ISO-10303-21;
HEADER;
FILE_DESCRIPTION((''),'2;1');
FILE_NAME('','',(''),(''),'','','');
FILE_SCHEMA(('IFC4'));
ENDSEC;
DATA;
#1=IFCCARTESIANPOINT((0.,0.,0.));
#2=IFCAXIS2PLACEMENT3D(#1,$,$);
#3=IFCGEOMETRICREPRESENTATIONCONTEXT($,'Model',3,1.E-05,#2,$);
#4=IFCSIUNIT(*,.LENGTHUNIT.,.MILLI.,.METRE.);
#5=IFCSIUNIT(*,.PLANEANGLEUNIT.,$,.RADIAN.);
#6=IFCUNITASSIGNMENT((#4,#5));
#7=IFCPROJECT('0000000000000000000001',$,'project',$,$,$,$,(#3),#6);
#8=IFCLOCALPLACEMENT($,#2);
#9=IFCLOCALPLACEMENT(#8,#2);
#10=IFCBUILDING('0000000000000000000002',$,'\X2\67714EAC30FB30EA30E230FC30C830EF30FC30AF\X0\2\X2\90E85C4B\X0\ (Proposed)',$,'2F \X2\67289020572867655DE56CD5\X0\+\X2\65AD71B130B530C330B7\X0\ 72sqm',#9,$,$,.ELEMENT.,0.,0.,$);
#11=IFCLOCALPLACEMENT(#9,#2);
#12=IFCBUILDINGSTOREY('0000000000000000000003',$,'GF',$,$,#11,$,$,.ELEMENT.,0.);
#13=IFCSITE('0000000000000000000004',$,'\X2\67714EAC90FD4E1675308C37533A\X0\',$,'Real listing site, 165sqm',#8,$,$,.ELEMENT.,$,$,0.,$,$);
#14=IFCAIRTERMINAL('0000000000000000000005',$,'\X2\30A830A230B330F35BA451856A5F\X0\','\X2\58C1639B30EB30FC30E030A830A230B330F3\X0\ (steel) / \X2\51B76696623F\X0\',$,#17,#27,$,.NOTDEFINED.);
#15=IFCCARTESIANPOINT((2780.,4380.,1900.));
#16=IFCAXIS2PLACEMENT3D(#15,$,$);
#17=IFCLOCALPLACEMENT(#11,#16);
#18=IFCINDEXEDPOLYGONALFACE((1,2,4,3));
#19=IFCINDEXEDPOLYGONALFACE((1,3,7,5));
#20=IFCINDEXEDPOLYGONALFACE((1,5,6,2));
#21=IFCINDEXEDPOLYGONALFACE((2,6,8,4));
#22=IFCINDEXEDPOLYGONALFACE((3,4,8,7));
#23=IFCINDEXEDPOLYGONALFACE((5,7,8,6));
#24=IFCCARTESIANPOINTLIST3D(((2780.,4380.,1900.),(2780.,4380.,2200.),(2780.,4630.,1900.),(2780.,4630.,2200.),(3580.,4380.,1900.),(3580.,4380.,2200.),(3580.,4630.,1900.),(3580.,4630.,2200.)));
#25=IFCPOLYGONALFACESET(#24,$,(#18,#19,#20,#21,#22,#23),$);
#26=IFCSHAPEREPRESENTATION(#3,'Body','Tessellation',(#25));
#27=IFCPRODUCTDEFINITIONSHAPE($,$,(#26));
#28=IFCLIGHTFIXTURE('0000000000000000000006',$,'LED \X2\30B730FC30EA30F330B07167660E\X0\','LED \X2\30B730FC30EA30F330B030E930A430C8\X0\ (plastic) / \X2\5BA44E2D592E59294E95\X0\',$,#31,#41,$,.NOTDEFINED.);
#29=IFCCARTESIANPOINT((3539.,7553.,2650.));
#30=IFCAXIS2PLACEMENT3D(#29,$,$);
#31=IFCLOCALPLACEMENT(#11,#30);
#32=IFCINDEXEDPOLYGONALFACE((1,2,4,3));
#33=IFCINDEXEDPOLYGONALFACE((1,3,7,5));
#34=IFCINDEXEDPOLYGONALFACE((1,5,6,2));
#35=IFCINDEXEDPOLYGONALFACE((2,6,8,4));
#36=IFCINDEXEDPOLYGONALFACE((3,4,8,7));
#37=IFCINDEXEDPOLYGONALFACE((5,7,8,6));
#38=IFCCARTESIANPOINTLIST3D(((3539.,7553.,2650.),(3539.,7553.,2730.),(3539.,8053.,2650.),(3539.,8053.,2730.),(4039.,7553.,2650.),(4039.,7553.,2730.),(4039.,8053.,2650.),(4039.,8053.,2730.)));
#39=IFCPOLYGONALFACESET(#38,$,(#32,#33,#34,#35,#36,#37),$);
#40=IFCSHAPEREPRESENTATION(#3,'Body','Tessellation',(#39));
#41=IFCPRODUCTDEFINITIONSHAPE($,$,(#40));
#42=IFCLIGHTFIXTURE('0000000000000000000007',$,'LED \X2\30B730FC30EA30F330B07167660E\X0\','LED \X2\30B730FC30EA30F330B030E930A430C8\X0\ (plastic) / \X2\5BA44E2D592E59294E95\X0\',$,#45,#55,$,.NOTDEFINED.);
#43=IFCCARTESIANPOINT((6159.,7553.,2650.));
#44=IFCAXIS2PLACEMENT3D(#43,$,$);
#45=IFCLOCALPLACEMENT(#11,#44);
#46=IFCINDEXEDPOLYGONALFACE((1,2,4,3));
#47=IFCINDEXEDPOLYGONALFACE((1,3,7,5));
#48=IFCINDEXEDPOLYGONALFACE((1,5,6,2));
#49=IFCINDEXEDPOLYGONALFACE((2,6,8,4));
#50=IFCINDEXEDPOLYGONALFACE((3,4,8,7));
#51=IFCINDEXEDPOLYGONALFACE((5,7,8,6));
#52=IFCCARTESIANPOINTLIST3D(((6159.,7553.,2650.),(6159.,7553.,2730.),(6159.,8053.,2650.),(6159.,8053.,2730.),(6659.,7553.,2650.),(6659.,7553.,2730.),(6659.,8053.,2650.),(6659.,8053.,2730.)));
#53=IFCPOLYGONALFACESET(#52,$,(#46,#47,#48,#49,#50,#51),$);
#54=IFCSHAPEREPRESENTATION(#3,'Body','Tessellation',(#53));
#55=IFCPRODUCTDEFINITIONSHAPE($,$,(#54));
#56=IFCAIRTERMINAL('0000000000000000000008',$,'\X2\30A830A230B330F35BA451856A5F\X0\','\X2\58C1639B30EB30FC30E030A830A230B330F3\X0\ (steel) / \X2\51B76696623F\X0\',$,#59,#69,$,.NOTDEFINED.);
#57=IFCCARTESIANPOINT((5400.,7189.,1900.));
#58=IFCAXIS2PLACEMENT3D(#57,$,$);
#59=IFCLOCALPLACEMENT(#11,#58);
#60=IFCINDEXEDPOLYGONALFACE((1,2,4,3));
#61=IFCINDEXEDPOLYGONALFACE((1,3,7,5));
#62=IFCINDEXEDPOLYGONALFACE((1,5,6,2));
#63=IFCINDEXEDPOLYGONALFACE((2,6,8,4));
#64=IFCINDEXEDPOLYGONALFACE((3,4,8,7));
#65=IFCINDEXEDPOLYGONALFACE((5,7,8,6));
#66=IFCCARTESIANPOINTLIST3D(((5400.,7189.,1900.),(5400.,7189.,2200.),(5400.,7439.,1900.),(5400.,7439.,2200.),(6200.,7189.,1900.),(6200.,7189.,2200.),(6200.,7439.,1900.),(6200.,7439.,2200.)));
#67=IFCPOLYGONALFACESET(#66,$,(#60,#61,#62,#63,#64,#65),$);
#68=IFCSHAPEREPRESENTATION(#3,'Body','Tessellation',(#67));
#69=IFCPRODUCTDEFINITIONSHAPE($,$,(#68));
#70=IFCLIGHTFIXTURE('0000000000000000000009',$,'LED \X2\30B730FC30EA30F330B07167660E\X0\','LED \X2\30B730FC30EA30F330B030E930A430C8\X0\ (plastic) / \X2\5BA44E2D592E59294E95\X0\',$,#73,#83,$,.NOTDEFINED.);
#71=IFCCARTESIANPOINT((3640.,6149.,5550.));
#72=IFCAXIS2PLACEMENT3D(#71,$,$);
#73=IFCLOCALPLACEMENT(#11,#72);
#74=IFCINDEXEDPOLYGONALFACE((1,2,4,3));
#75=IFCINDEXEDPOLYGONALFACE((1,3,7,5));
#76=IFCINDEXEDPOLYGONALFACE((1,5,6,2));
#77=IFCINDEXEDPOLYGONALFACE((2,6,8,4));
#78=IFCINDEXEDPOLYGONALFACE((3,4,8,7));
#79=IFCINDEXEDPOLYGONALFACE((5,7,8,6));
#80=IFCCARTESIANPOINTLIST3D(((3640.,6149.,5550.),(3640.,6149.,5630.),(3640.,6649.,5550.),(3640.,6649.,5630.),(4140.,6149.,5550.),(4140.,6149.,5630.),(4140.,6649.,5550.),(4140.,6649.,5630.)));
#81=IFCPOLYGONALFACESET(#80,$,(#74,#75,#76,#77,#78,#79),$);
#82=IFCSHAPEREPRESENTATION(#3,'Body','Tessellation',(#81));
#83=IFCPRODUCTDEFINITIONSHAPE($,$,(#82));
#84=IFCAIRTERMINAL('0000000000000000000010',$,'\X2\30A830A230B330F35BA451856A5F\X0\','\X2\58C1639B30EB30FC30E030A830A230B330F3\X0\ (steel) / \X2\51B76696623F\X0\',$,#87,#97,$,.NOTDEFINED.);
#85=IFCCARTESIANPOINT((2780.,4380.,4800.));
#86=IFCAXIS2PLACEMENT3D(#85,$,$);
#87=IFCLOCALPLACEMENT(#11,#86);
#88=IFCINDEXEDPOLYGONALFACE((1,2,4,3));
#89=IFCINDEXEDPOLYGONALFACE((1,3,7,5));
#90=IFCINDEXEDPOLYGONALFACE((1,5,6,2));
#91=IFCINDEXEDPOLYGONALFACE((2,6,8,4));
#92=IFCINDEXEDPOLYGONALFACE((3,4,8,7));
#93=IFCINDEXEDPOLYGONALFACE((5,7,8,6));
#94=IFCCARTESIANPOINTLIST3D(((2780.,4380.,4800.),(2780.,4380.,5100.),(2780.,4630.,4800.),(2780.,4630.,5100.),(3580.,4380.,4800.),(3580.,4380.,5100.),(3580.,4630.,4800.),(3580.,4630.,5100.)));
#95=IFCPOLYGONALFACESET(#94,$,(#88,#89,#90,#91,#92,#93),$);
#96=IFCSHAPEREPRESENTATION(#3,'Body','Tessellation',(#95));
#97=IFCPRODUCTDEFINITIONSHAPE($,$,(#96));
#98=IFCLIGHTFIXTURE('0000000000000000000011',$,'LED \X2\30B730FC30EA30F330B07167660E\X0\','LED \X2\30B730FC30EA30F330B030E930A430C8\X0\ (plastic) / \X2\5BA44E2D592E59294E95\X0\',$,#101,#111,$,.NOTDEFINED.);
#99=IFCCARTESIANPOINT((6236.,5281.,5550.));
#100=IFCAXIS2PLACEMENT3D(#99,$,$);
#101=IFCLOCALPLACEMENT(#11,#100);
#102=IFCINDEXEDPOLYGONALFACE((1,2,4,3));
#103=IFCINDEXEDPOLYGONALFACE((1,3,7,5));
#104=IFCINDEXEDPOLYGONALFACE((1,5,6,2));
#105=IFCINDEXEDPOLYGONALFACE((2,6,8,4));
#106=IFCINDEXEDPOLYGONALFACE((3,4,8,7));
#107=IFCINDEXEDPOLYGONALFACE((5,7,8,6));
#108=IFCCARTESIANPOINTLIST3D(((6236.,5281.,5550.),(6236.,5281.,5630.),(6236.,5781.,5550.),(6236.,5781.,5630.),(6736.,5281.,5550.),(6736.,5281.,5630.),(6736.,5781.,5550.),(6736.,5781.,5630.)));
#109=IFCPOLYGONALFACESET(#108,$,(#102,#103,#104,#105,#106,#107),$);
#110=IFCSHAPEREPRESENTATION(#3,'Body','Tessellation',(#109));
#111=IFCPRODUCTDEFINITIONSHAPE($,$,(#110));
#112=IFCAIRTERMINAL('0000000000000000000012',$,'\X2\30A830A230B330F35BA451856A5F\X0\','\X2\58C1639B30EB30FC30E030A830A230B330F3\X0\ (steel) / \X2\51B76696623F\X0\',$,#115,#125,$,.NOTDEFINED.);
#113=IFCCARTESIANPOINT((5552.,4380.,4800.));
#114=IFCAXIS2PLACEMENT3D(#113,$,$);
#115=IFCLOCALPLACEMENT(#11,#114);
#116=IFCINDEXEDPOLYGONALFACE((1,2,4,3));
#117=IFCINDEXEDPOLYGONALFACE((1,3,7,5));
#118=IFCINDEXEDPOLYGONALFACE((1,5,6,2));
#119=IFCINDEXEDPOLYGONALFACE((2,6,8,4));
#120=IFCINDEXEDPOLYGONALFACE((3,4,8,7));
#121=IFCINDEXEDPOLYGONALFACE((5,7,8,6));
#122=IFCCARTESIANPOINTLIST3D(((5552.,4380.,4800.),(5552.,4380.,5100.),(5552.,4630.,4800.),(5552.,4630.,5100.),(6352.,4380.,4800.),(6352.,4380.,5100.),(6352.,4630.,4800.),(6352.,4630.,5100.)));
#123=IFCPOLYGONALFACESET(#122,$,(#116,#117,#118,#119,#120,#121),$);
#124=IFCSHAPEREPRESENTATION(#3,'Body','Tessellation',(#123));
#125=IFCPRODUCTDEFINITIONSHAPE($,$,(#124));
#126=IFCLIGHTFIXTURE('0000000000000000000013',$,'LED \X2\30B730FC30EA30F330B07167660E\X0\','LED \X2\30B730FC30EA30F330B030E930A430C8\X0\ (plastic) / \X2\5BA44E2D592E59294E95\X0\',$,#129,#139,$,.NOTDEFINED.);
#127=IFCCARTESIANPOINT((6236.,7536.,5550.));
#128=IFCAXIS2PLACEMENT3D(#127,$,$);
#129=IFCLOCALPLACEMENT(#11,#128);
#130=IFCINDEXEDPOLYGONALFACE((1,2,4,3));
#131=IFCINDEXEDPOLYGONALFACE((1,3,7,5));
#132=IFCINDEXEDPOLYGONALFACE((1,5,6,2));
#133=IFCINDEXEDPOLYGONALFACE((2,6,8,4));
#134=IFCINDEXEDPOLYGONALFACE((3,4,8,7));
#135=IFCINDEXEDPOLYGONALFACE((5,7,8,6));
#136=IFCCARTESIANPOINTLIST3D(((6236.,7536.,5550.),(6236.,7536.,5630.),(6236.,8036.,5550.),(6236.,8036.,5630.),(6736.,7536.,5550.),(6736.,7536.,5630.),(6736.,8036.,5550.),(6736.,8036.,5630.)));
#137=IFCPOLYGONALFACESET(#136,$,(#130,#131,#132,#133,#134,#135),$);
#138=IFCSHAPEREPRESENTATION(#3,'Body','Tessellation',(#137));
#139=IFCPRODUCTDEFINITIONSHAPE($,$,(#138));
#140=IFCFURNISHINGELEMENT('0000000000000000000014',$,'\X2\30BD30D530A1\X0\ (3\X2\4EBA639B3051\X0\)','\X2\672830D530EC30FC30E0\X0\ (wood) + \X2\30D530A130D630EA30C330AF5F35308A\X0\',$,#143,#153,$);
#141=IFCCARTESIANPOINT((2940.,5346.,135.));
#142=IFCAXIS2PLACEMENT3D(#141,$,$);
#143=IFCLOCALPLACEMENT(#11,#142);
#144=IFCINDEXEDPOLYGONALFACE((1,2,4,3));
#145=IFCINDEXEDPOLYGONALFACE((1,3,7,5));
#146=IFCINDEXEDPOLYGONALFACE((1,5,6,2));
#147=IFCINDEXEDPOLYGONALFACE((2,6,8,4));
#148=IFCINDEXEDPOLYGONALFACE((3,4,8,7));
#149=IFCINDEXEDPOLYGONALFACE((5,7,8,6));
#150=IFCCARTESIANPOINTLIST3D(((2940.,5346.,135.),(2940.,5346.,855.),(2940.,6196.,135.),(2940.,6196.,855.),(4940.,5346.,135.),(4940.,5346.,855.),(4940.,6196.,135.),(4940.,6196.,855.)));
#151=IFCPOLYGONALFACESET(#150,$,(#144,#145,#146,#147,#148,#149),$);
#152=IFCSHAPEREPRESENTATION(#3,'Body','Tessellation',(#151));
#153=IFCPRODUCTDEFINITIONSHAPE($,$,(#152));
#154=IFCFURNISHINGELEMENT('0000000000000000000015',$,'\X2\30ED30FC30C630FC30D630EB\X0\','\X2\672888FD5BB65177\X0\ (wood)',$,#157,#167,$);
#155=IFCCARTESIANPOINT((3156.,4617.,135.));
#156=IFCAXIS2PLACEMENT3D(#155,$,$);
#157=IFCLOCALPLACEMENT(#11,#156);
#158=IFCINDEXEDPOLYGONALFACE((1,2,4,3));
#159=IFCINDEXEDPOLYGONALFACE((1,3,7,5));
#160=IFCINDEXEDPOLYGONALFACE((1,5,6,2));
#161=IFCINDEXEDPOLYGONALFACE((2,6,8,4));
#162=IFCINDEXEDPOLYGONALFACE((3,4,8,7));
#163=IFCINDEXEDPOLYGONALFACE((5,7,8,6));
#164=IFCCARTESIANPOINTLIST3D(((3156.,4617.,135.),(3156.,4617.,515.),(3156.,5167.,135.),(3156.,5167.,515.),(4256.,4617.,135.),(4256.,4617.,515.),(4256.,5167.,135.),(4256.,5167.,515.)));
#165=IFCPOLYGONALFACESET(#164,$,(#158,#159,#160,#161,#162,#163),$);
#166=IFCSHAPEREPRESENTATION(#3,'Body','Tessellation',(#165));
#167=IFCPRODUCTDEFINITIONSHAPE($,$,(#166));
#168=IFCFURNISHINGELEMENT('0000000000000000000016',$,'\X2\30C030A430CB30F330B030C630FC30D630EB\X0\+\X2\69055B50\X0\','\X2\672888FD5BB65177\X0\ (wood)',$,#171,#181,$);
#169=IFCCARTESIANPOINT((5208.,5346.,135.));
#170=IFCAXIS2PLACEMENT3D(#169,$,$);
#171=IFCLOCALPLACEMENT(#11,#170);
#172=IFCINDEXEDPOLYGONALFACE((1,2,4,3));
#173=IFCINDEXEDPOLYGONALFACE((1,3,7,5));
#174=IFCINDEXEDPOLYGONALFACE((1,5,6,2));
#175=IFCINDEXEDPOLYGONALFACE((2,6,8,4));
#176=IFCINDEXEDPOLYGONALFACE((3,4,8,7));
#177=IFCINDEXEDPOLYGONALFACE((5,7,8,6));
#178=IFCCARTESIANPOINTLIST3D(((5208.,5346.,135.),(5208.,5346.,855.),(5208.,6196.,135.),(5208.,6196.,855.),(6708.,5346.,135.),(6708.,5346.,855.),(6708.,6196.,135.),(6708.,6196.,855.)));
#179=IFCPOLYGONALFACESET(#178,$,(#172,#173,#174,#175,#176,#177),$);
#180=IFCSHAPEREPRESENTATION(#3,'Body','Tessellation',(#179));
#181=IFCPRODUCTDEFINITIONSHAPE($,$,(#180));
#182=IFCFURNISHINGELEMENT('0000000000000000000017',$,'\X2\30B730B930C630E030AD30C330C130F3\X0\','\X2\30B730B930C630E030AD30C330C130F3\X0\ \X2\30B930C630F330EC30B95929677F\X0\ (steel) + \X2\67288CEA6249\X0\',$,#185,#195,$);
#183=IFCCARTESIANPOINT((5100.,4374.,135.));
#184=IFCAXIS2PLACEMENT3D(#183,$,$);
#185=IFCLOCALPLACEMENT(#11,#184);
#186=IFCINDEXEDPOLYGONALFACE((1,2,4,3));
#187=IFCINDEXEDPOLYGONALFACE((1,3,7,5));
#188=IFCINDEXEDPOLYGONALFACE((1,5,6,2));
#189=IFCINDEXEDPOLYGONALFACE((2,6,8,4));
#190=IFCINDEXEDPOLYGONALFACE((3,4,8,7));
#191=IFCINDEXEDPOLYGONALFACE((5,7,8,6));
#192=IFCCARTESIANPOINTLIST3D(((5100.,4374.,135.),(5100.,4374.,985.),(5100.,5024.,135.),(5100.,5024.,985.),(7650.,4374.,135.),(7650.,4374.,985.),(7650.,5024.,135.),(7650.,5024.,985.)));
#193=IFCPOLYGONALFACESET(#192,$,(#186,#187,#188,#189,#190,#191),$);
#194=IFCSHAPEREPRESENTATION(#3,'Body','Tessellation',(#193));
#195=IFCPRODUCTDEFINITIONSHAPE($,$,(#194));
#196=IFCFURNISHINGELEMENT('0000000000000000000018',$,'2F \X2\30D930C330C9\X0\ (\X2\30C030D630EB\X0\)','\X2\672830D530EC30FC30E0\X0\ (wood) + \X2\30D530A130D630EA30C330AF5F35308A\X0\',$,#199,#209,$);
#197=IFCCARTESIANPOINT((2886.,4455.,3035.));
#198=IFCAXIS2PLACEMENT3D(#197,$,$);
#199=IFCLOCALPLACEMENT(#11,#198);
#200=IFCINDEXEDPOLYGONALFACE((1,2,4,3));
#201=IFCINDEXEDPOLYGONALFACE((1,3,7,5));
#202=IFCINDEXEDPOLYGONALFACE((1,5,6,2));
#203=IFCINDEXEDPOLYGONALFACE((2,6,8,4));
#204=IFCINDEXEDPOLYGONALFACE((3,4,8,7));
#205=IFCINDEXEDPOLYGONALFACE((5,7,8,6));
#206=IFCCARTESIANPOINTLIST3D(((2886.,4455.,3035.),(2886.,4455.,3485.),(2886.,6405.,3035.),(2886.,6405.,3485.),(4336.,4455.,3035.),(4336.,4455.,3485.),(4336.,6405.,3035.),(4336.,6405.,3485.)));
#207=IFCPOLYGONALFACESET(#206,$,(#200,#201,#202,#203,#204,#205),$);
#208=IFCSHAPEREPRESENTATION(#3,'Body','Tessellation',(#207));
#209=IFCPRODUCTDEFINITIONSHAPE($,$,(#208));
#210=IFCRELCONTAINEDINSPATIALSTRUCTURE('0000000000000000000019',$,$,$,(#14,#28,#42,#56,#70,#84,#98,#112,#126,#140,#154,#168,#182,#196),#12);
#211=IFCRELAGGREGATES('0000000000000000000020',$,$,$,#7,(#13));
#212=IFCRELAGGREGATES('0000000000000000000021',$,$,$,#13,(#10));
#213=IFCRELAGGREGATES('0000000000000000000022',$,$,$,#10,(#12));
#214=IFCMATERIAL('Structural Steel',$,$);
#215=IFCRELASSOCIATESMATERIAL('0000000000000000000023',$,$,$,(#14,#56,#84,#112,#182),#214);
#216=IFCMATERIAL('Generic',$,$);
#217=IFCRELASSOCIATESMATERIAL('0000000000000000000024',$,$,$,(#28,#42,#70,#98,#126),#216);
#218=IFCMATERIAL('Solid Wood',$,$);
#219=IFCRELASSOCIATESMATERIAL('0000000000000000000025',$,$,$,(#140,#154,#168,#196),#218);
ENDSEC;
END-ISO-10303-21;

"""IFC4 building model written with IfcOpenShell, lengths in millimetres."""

from ifc_helpers import new_model, si_unit, frame, frame_2d, origin, place, context, project, spatial, rectangle, extrude, material, element, save


model = new_model("IFC4")

# Units and contexts
model_context = context("Model", 3, precision=1e-05, world=origin())
ifc_project = project(units=[si_unit("LENGTHUNIT", "METRE", prefix="MILLI"), si_unit("PLANEANGLEUNIT", "RADIAN")], contexts=[model_context])

# Site, building, storey
site_placement = place(None, origin())
site = spatial("IfcSite", under=ifc_project, at=site_placement, Name="東京都世田谷区", ObjectType="Real listing site, 165sqm", CompositionType="ELEMENT", RefElevation=0.0)
building_placement = place(site_placement, origin())
building = spatial("IfcBuilding", under=site, at=building_placement, Name="東京・リモートワーク2部屋 (Proposed)", ObjectType="2F 木造在来工法+断熱サッシ 72sqm", CompositionType="ELEMENT", ElevationOfRefHeight=0.0, ElevationOfTerrain=0.0)
storey_placement = place(building_placement, origin())
storey = spatial("IfcBuildingStorey", under=building, at=storey_placement, Name="GF", CompositionType="ELEMENT", Elevation=0.0)

# Shared definitions
ifc_material_1 = material(Name="Solid Wood")

# Shared definitions
ifc_material_2 = material(Name="Structural Steel")

# Shared definitions
ifc_material_3 = material(Name="Generic")

# Air terminal
air_terminal_1_placement = place(storey_placement, frame((2780.0, 4380.0, 1900.0)))
element("IfcAirTerminal", 1, at=air_terminal_1_placement, inside=storey, material=ifc_material_2, Name="エアコン室内機", Description="壁掛ルームエアコン (steel) / 冷暖房", PredefinedType="NOTDEFINED", context=model_context, shape_type="SweptSolid", body=[
    extrude(rectangle(XDim=800.0, YDim=250.0, at=frame_2d((400.0, 125.0))), frame((2780.0, 4380.0, 1900.0)), (0.0, 0.0, 1.0), 300.0),
])

# Light fixtures
light_fixture_1_placement = place(storey_placement, frame((3539.0, 7553.0, 2650.0)))
element("IfcLightFixture", 2, at=light_fixture_1_placement, inside=storey, material=ifc_material_3, Name="LED シーリング照明", Description="LED シーリングライト (plastic) / 室中央天井", PredefinedType="NOTDEFINED", context=model_context, shape_type="SweptSolid", body=[
    extrude(rectangle(XDim=500.0, YDim=500.0, at=frame_2d((250.0, 250.0))), frame((3539.0, 7553.0, 2650.0)), (0.0, 0.0, 1.0), 80.0),
])
light_fixture_2_placement = place(storey_placement, frame((6159.0, 7553.0, 2650.0)))
element("IfcLightFixture", 3, at=light_fixture_2_placement, inside=storey, material=ifc_material_3, Name="LED シーリング照明", Description="LED シーリングライト (plastic) / 室中央天井", PredefinedType="NOTDEFINED", context=model_context, shape_type="SweptSolid", body=[
    extrude(rectangle(XDim=500.0, YDim=500.0, at=frame_2d((250.0, 250.0))), frame((6159.0, 7553.0, 2650.0)), (0.0, 0.0, 1.0), 80.0),
])

# Air terminal
air_terminal_2_placement = place(storey_placement, frame((5400.0, 7189.0, 1900.0)))
element("IfcAirTerminal", 4, at=air_terminal_2_placement, inside=storey, material=ifc_material_2, Name="エアコン室内機", Description="壁掛ルームエアコン (steel) / 冷暖房", PredefinedType="NOTDEFINED", context=model_context, shape_type="SweptSolid", body=[
    extrude(rectangle(XDim=800.0, YDim=250.0, at=frame_2d((400.0, 125.0))), frame((5400.0, 7189.0, 1900.0)), (0.0, 0.0, 1.0), 300.0),
])

# Light fixture
light_fixture_3_placement = place(storey_placement, frame((3640.0, 6149.0, 5550.0)))
element("IfcLightFixture", 5, at=light_fixture_3_placement, inside=storey, material=ifc_material_3, Name="LED シーリング照明", Description="LED シーリングライト (plastic) / 室中央天井", PredefinedType="NOTDEFINED", context=model_context, shape_type="SweptSolid", body=[
    extrude(rectangle(XDim=500.0, YDim=500.0, at=frame_2d((250.0, 250.0))), frame((3640.0, 6149.0, 5550.0)), (0.0, 0.0, 1.0), 80.0),
])

# Air terminal
air_terminal_3_placement = place(storey_placement, frame((2780.0, 4380.0, 4800.0)))
element("IfcAirTerminal", 6, at=air_terminal_3_placement, inside=storey, material=ifc_material_2, Name="エアコン室内機", Description="壁掛ルームエアコン (steel) / 冷暖房", PredefinedType="NOTDEFINED", context=model_context, shape_type="SweptSolid", body=[
    extrude(rectangle(XDim=800.0, YDim=250.0, at=frame_2d((400.0, 125.0))), frame((2780.0, 4380.0, 4800.0)), (0.0, 0.0, 1.0), 300.0),
])

# Light fixture
light_fixture_4_placement = place(storey_placement, frame((6236.0, 5281.0, 5550.0)))
element("IfcLightFixture", 7, at=light_fixture_4_placement, inside=storey, material=ifc_material_3, Name="LED シーリング照明", Description="LED シーリングライト (plastic) / 室中央天井", PredefinedType="NOTDEFINED", context=model_context, shape_type="SweptSolid", body=[
    extrude(rectangle(XDim=500.0, YDim=500.0, at=frame_2d((250.0, 250.0))), frame((6236.0, 5281.0, 5550.0)), (0.0, 0.0, 1.0), 80.0),
])

# Air terminal
air_terminal_4_placement = place(storey_placement, frame((5552.0, 4380.0, 4800.0)))
element("IfcAirTerminal", 8, at=air_terminal_4_placement, inside=storey, material=ifc_material_2, Name="エアコン室内機", Description="壁掛ルームエアコン (steel) / 冷暖房", PredefinedType="NOTDEFINED", context=model_context, shape_type="SweptSolid", body=[
    extrude(rectangle(XDim=800.0, YDim=250.0, at=frame_2d((400.0, 125.0))), frame((5552.0, 4380.0, 4800.0)), (0.0, 0.0, 1.0), 300.0),
])

# Light fixture
light_fixture_5_placement = place(storey_placement, frame((6236.0, 7536.0, 5550.0)))
element("IfcLightFixture", 9, at=light_fixture_5_placement, inside=storey, material=ifc_material_3, Name="LED シーリング照明", Description="LED シーリングライト (plastic) / 室中央天井", PredefinedType="NOTDEFINED", context=model_context, shape_type="SweptSolid", body=[
    extrude(rectangle(XDim=500.0, YDim=500.0, at=frame_2d((250.0, 250.0))), frame((6236.0, 7536.0, 5550.0)), (0.0, 0.0, 1.0), 80.0),
])

# Furnishing elements
furnishing_1_placement = place(storey_placement, frame((2940.0, 5346.0, 135.0)))
element("IfcFurnishingElement", 10, at=furnishing_1_placement, inside=storey, material=ifc_material_1, Name="ソファ (3人掛け)", Description="木フレーム (wood) + ファブリック張り", context=model_context, shape_type="SweptSolid", body=[
    extrude(rectangle(XDim=2000.0, YDim=850.0, at=frame_2d((1000.0, 425.0))), frame((2940.0, 5346.0, 135.0)), (0.0, 0.0, 1.0), 720.0),
])
furnishing_2_placement = place(storey_placement, frame((3156.0, 4617.0, 135.0)))
element("IfcFurnishingElement", 11, at=furnishing_2_placement, inside=storey, material=ifc_material_1, Name="ローテーブル", Description="木製家具 (wood)", context=model_context, shape_type="SweptSolid", body=[
    extrude(rectangle(XDim=1100.0, YDim=550.0, at=frame_2d((550.0, 275.0))), frame((3156.0, 4617.0, 135.0)), (0.0, 0.0, 1.0), 380.0),
])
furnishing_3_placement = place(storey_placement, frame((5208.0, 5346.0, 135.0)))
element("IfcFurnishingElement", 12, at=furnishing_3_placement, inside=storey, material=ifc_material_1, Name="ダイニングテーブル+椅子", Description="木製家具 (wood)", context=model_context, shape_type="SweptSolid", body=[
    extrude(rectangle(XDim=1500.0, YDim=850.0, at=frame_2d((750.0, 425.0))), frame((5208.0, 5346.0, 135.0)), (0.0, 0.0, 1.0), 720.0),
])
furnishing_4_placement = place(storey_placement, frame((5100.0, 4374.0, 135.0)))
element("IfcFurnishingElement", 13, at=furnishing_4_placement, inside=storey, material=ifc_material_2, Name="システムキッチン", Description="システムキッチン ステンレス天板 (steel) + 木質扉", context=model_context, shape_type="SweptSolid", body=[
    extrude(rectangle(XDim=2550.0, YDim=650.0, at=frame_2d((1275.0, 325.0))), frame((5100.0, 4374.0, 135.0)), (0.0, 0.0, 1.0), 850.0),
])
furnishing_5_placement = place(storey_placement, frame((2886.0, 4455.0, 3035.0)))
element("IfcFurnishingElement", 14, at=furnishing_5_placement, inside=storey, material=ifc_material_1, Name="2F ベッド (ダブル)", Description="木フレーム (wood) + ファブリック張り", context=model_context, shape_type="SweptSolid", body=[
    extrude(rectangle(XDim=1450.0, YDim=1950.0, at=frame_2d((725.0, 975.0))), frame((2886.0, 4455.0, 3035.0)), (0.0, 0.0, 1.0), 450.0),
])

save(model, "model.ifc")
